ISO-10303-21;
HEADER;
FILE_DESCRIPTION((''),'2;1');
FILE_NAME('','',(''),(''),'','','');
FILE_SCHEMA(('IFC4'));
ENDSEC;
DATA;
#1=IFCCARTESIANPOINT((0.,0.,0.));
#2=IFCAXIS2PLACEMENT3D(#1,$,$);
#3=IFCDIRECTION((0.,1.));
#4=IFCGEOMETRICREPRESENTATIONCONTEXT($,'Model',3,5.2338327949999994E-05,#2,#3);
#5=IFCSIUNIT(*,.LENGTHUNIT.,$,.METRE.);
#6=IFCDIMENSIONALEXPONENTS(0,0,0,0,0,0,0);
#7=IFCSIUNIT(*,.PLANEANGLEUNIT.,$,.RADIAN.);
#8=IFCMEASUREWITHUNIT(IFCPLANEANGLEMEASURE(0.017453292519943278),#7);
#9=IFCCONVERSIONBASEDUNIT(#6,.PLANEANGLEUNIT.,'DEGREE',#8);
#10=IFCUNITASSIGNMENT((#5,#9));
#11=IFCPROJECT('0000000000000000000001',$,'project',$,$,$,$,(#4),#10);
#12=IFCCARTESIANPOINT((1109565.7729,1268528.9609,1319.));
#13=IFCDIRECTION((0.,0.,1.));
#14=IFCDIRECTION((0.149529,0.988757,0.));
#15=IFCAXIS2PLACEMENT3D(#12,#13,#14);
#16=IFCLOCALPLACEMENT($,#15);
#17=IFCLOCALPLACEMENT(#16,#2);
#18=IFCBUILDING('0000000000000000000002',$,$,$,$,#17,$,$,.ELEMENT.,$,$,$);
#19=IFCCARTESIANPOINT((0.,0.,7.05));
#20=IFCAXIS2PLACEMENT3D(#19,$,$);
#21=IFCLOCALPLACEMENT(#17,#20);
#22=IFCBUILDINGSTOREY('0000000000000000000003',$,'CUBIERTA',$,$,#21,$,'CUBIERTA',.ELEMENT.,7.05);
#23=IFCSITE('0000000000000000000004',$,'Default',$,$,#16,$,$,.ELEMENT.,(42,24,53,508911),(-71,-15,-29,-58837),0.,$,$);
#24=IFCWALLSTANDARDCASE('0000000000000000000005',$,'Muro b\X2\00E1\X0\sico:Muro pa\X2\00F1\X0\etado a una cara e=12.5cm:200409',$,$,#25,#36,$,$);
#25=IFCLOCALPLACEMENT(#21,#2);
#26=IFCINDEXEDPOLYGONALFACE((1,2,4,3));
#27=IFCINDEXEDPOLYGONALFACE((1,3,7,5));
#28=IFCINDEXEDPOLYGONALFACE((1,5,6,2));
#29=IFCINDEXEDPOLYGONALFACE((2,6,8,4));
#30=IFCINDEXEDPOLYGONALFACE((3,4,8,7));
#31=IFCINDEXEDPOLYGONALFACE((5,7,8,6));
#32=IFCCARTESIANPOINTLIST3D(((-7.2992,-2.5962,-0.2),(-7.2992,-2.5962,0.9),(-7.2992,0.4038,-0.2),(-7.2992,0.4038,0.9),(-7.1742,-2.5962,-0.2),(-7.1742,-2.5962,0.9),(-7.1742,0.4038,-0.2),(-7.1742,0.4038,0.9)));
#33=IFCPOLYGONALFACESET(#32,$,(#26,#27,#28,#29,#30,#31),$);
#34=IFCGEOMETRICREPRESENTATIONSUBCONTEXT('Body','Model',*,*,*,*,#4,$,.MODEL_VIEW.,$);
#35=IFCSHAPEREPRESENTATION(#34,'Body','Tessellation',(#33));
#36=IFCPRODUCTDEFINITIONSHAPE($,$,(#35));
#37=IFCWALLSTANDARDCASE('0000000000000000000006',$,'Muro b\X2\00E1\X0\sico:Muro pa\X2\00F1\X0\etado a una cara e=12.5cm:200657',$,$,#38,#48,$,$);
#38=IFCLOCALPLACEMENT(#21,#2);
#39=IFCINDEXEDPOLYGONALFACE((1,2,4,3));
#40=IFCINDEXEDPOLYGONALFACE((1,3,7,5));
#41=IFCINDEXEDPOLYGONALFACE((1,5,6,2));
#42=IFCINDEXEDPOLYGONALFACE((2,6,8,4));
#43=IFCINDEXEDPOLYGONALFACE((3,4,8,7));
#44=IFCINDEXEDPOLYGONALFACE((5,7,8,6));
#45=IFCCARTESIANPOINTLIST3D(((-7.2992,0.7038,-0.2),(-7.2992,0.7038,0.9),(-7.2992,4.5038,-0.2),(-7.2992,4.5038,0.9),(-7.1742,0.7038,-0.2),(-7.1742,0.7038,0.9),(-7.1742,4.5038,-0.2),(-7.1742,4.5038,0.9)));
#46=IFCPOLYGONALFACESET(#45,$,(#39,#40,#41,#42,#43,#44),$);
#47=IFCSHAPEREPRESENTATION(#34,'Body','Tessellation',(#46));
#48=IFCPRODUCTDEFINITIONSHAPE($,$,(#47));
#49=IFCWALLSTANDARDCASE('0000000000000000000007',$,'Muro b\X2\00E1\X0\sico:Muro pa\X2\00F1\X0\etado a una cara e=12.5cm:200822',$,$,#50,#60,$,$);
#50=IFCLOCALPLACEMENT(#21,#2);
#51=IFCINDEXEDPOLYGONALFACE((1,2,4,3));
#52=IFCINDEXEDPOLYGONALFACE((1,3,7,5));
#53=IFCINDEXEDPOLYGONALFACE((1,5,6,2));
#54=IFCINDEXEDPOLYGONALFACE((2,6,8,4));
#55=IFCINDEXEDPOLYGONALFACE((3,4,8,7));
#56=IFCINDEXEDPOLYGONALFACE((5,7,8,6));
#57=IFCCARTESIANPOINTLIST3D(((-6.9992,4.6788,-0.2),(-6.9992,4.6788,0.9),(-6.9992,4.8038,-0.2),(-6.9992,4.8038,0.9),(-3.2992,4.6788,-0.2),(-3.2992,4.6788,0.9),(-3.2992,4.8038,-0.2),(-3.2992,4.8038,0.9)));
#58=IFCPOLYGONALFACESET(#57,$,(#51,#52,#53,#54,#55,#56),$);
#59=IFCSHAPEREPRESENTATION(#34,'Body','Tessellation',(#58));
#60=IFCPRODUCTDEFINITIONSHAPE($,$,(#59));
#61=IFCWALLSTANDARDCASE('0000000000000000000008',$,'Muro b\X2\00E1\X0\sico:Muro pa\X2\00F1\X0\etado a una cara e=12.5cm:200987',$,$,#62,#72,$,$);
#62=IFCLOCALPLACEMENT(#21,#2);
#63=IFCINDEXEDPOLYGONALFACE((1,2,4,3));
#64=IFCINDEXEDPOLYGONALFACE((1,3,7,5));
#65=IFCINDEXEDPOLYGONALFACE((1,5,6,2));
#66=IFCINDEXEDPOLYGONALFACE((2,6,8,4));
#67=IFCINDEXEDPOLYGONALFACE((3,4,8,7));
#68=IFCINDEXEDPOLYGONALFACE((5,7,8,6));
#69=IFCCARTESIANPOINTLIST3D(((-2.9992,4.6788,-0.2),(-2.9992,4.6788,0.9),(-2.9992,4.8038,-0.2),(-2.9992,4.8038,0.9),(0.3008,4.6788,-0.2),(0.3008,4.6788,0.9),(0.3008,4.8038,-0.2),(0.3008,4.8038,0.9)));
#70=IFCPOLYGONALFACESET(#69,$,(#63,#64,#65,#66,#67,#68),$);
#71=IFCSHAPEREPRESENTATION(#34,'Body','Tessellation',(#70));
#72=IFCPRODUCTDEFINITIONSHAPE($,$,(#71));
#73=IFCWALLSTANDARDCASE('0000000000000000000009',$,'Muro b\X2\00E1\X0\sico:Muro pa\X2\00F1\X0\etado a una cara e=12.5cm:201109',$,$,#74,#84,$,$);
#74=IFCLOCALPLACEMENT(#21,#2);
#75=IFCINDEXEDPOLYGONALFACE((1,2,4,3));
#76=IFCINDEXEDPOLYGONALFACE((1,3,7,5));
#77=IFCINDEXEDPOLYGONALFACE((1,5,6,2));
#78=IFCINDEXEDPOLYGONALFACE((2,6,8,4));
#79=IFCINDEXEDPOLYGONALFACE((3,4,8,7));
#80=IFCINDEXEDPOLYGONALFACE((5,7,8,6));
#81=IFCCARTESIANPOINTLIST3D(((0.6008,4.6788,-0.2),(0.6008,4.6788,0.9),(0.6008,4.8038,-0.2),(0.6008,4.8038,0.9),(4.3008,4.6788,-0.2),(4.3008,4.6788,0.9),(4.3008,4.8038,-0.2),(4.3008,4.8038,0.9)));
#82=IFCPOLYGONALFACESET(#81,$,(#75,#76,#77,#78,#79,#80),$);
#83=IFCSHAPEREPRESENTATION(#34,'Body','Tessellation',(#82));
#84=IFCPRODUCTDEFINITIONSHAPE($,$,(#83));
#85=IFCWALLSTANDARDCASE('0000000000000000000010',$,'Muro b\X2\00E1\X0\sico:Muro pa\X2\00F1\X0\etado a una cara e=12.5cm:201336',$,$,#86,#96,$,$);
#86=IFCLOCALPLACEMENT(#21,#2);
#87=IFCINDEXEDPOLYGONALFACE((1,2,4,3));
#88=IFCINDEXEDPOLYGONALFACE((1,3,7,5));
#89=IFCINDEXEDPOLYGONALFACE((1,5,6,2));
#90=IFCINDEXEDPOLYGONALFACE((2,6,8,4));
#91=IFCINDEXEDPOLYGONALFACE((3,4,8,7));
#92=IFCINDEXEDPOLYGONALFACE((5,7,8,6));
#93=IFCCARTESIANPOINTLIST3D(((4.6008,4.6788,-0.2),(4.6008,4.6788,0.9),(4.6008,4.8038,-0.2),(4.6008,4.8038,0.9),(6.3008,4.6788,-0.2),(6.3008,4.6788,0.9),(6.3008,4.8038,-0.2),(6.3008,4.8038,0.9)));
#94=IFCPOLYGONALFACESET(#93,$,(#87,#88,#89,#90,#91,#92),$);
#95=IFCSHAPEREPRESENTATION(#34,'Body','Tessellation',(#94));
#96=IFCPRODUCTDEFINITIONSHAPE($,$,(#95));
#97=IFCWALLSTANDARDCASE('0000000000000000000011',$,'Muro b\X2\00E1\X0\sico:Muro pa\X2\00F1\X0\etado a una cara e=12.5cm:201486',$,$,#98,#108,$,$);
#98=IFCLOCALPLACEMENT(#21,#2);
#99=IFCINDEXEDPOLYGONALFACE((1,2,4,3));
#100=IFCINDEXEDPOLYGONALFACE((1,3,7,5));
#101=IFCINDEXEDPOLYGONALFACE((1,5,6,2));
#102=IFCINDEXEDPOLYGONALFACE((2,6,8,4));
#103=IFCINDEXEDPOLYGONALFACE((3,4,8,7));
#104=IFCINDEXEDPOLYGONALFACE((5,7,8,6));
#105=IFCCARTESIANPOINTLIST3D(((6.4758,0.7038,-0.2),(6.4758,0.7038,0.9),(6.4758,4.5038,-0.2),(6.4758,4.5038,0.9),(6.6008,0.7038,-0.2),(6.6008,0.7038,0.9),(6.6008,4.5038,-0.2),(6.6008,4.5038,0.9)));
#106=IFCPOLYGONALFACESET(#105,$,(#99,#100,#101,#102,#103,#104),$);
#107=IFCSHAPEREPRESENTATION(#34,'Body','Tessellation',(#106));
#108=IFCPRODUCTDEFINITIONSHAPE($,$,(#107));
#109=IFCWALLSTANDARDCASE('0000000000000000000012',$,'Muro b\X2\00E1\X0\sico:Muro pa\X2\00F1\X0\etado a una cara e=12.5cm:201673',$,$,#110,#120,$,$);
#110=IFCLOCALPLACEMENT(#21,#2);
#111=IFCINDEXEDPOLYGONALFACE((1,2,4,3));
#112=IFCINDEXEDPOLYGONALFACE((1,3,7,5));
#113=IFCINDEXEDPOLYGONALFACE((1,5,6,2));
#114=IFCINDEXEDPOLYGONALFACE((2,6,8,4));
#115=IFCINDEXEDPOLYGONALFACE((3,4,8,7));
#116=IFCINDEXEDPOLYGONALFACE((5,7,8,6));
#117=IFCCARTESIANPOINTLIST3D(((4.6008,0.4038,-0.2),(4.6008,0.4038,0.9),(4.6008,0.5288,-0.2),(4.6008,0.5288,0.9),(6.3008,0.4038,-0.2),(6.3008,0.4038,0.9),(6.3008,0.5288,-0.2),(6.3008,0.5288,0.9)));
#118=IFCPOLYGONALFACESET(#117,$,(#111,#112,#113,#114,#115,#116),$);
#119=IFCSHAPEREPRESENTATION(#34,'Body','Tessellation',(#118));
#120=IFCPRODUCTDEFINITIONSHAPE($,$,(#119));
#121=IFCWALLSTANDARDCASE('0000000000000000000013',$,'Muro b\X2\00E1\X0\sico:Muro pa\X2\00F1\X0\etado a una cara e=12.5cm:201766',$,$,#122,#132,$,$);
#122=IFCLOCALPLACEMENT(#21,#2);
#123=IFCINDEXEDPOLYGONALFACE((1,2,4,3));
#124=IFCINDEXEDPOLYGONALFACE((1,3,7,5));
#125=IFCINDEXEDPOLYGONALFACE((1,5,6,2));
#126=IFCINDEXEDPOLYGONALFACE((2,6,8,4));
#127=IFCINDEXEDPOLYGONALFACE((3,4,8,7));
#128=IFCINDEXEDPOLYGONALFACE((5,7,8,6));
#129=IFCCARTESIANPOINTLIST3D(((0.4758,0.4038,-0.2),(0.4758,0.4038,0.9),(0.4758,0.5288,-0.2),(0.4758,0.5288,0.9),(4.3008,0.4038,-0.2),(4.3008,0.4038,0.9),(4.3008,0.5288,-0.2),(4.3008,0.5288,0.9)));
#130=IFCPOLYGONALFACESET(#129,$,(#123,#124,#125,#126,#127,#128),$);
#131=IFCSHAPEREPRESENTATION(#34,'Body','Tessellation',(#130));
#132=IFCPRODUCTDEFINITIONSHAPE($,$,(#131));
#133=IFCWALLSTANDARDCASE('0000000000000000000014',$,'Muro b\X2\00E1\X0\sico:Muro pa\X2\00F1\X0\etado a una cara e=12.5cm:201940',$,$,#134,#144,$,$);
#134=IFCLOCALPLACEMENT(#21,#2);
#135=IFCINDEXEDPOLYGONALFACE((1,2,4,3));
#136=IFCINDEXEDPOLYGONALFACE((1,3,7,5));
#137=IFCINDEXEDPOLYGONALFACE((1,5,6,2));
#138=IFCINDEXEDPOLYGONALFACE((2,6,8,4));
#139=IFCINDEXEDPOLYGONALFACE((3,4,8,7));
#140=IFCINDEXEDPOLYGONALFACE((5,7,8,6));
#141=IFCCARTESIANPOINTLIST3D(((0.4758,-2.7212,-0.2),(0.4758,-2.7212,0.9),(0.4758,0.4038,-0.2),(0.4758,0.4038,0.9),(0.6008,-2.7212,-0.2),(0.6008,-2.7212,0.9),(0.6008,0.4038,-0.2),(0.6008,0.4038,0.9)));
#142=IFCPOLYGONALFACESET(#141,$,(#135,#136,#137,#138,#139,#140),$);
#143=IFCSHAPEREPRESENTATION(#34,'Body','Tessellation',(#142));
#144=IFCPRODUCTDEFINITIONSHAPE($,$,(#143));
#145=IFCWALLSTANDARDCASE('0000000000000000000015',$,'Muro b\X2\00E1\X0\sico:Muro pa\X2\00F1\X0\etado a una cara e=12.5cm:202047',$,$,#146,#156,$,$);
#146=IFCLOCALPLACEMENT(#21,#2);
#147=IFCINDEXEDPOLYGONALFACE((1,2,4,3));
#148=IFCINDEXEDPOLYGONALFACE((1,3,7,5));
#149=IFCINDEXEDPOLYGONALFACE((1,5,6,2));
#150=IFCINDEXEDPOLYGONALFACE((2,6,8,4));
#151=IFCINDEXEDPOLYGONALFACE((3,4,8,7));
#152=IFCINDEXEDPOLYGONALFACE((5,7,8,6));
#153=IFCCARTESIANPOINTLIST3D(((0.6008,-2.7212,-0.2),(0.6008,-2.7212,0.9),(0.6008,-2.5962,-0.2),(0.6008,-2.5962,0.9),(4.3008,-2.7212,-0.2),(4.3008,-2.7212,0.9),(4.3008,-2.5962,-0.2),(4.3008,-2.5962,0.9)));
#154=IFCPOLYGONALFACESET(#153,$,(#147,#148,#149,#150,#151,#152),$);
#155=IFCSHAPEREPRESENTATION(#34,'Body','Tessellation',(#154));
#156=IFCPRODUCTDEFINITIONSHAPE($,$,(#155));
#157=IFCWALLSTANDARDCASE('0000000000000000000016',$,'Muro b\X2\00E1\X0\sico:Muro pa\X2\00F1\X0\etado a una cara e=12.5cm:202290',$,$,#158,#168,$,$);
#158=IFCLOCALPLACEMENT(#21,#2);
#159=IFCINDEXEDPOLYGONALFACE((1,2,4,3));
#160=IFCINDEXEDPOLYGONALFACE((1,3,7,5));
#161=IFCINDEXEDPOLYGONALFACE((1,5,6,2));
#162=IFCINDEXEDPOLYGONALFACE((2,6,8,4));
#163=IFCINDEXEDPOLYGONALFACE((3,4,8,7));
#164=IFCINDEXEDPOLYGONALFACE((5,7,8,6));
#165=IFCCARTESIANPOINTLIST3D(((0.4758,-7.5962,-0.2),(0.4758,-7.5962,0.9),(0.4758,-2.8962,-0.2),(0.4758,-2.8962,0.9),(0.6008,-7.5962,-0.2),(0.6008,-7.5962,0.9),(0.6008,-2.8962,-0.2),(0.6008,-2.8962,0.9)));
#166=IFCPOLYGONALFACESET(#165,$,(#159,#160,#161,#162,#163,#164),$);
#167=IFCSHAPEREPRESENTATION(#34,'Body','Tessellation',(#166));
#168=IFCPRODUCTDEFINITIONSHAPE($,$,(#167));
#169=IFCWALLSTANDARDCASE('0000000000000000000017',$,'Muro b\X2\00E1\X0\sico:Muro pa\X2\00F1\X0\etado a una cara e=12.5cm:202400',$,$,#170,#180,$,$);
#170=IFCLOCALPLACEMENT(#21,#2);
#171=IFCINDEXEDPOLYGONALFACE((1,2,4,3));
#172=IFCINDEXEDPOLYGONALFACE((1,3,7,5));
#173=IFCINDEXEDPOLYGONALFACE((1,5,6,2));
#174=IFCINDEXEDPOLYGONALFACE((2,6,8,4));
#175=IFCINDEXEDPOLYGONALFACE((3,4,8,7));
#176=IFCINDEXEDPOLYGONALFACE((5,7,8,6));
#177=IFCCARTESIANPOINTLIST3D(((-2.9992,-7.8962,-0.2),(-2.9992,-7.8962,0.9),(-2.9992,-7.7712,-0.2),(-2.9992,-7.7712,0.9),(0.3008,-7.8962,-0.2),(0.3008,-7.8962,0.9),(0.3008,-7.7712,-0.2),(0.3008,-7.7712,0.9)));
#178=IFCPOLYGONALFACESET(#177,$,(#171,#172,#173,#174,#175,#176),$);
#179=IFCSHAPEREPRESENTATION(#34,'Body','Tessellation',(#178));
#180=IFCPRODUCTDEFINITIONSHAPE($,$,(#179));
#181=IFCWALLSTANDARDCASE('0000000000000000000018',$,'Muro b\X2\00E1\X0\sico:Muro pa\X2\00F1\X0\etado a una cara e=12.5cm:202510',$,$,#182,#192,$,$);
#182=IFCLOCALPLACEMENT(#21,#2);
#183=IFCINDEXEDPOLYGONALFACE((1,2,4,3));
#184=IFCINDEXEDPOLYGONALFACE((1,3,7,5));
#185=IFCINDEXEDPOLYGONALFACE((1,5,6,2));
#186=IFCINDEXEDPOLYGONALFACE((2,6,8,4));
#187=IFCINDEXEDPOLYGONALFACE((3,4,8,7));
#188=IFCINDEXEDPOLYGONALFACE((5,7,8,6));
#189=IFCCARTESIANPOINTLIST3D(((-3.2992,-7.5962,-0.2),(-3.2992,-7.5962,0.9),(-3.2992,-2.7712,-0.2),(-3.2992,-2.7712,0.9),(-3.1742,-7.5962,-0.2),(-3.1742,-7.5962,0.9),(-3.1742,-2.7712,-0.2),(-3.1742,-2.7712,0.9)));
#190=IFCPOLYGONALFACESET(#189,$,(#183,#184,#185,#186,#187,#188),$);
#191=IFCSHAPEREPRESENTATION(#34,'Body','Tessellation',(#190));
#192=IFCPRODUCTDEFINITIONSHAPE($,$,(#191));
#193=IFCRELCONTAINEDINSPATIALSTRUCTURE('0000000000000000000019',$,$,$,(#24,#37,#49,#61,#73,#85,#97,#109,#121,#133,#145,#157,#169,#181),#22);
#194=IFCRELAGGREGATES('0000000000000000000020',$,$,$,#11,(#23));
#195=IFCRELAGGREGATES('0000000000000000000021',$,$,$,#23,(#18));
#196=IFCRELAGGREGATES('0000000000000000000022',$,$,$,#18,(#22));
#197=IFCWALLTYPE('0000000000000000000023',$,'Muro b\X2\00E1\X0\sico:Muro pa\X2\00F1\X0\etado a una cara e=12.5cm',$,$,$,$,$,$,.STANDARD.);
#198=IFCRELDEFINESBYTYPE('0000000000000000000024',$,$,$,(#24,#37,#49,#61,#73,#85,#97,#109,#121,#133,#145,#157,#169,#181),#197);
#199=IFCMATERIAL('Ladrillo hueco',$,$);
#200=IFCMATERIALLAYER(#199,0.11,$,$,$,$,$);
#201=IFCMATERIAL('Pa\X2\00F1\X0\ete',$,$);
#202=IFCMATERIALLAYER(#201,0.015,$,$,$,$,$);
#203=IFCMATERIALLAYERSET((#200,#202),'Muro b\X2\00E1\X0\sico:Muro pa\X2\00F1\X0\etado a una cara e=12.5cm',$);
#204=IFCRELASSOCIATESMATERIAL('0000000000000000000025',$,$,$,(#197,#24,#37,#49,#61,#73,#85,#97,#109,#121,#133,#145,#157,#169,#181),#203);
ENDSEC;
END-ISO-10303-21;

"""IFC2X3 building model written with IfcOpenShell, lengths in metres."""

from ifc_helpers import new_model, entity, si_unit, converted_unit, direction, frame, frame_2d, origin, place, context, subcontext, project, spatial, rectangle, extrude, material, layer, layer_set, layer_usage, type_object, element, save


model = new_model("IFC2X3")

# Units and contexts
model_context = context("Model", 3, precision=5.2338327949999994e-05, world=origin(), true_north=direction((0.0, 1.0)))
body_context = subcontext(model_context, "Body", "Model", "MODEL_VIEW")
ifc_project = project(units=[si_unit("LENGTHUNIT", "METRE"), converted_unit("PLANEANGLEUNIT", "DEGREE", entity("IfcPlaneAngleMeasure", 0.017453292519943278), si_unit("PLANEANGLEUNIT", "RADIAN"), dimensions=[0, 0, 0, 0, 0, 0, 0])], contexts=[model_context])

# Site, building, storey
site_placement = place(None, frame((1109565.7729, 1268528.9609, 1319.0), z_axis=(0.0, 0.0, 1.0), x_axis=(0.149529, 0.988757, 0.0)))
site = spatial("IfcSite", under=ifc_project, at=site_placement, Name="Default", CompositionType="ELEMENT", RefLatitude=(42, 24, 53, 508911), RefLongitude=(-71, -15, -29, -58837), RefElevation=0.0)
building_placement = place(site_placement, origin())
building = spatial("IfcBuilding", under=site, at=building_placement, CompositionType="ELEMENT")
storey_placement = place(building_placement, frame((0.0, 0.0, 7.05)))
storey = spatial("IfcBuildingStorey", under=building, at=storey_placement, Name="CUBIERTA", LongName="CUBIERTA", CompositionType="ELEMENT", Elevation=7.05)

# Walls
ifc_material_1 = material(Name="Ladrillo hueco")
ifc_layer_1 = layer(ifc_material_1, 0.11)
ifc_material_2 = material(Name="Pañete")
ifc_layer_2 = layer(ifc_material_2, 0.015)
ifc_layer_set_1 = layer_set([ifc_layer_1, ifc_layer_2], Name="Muro básico:Muro pañetado a una cara e=12.5cm")
ifc_layer_usage_1 = layer_usage(ifc_layer_set_1, "AXIS2", "NEGATIVE", 0.0625)
wall_type_1 = type_object("IfcWallType", Name="Muro básico:Muro pañetado a una cara e=12.5cm", PredefinedType="STANDARD", material=ifc_layer_set_1)
wall_1_placement = place(storey_placement, frame((-7.2367, -2.5962, -0.2), z_axis=(0.0, 0.0, 1.0), x_axis=(0.0, 1.0, 0.0)))
element("IfcWallStandardCase", 1, at=wall_1_placement, inside=storey, type_object=wall_type_1, material=ifc_layer_usage_1, Name="Muro básico:Muro pañetado a una cara e=12.5cm:200409", context=body_context, shape_type="SweptSolid", body=[
    extrude(rectangle(XDim=3.0, YDim=0.125, at=frame_2d((1.5, 0.0), x_axis=(-1.0, 0.0))), origin(), (0.0, 0.0, 1.0), 1.1),
])
ifc_layer_usage_2 = layer_usage(ifc_layer_set_1, "AXIS2", "NEGATIVE", 0.0625)
wall_2_placement = place(storey_placement, frame((-7.2367, 0.7038, -0.2), z_axis=(0.0, 0.0, 1.0), x_axis=(0.0, 1.0, 0.0)))
element("IfcWallStandardCase", 2, at=wall_2_placement, inside=storey, type_object=wall_type_1, material=ifc_layer_usage_2, Name="Muro básico:Muro pañetado a una cara e=12.5cm:200657", context=body_context, shape_type="SweptSolid", body=[
    extrude(rectangle(XDim=3.8, YDim=0.125, at=frame_2d((1.9, 0.0), x_axis=(-1.0, 0.0))), origin(), (0.0, 0.0, 1.0), 1.1),
])
ifc_layer_usage_3 = layer_usage(ifc_layer_set_1, "AXIS2", "NEGATIVE", 0.0625)
wall_3_placement = place(storey_placement, frame((-6.9992, 4.7413, -0.2)))
element("IfcWallStandardCase", 3, at=wall_3_placement, inside=storey, type_object=wall_type_1, material=ifc_layer_usage_3, Name="Muro básico:Muro pañetado a una cara e=12.5cm:200822", context=body_context, shape_type="SweptSolid", body=[
    extrude(rectangle(XDim=3.7, YDim=0.125, at=frame_2d((1.85, 0.0), x_axis=(-1.0, 0.0))), origin(), (0.0, 0.0, 1.0), 1.1),
])
ifc_layer_usage_4 = layer_usage(ifc_layer_set_1, "AXIS2", "NEGATIVE", 0.0625)
wall_4_placement = place(storey_placement, frame((-2.9992, 4.7413, -0.2)))
element("IfcWallStandardCase", 4, at=wall_4_placement, inside=storey, type_object=wall_type_1, material=ifc_layer_usage_4, Name="Muro básico:Muro pañetado a una cara e=12.5cm:200987", context=body_context, shape_type="SweptSolid", body=[
    extrude(rectangle(XDim=3.3, YDim=0.125, at=frame_2d((1.65, 0.0), x_axis=(-1.0, 0.0))), origin(), (0.0, 0.0, 1.0), 1.1),
])
ifc_layer_usage_5 = layer_usage(ifc_layer_set_1, "AXIS2", "NEGATIVE", 0.0625)
wall_5_placement = place(storey_placement, frame((0.6008, 4.7413, -0.2)))
element("IfcWallStandardCase", 5, at=wall_5_placement, inside=storey, type_object=wall_type_1, material=ifc_layer_usage_5, Name="Muro básico:Muro pañetado a una cara e=12.5cm:201109", context=body_context, shape_type="SweptSolid", body=[
    extrude(rectangle(XDim=3.7, YDim=0.125, at=frame_2d((1.85, 0.0), x_axis=(-1.0, 0.0))), origin(), (0.0, 0.0, 1.0), 1.1),
])
ifc_layer_usage_6 = layer_usage(ifc_layer_set_1, "AXIS2", "NEGATIVE", 0.0625)
wall_6_placement = place(storey_placement, frame((4.6008, 4.7413, -0.2)))
element("IfcWallStandardCase", 6, at=wall_6_placement, inside=storey, type_object=wall_type_1, material=ifc_layer_usage_6, Name="Muro básico:Muro pañetado a una cara e=12.5cm:201336", context=body_context, shape_type="SweptSolid", body=[
    extrude(rectangle(XDim=1.7, YDim=0.125, at=frame_2d((0.85, 0.0), x_axis=(-1.0, 0.0))), origin(), (0.0, 0.0, 1.0), 1.1),
])
ifc_layer_usage_7 = layer_usage(ifc_layer_set_1, "AXIS2", "NEGATIVE", 0.0625)
wall_7_placement = place(storey_placement, frame((6.5383, 4.5038, -0.2), z_axis=(0.0, 0.0, 1.0), x_axis=(0.0, -1.0, 0.0)))
element("IfcWallStandardCase", 7, at=wall_7_placement, inside=storey, type_object=wall_type_1, material=ifc_layer_usage_7, Name="Muro básico:Muro pañetado a una cara e=12.5cm:201486", context=body_context, shape_type="SweptSolid", body=[
    extrude(rectangle(XDim=3.8, YDim=0.125, at=frame_2d((1.9, 0.0), x_axis=(-1.0, 0.0))), origin(), (0.0, 0.0, 1.0), 1.1),
])
ifc_layer_usage_8 = layer_usage(ifc_layer_set_1, "AXIS2", "NEGATIVE", 0.0625)
wall_8_placement = place(storey_placement, frame((6.3008, 0.4663, -0.2), z_axis=(0.0, 0.0, 1.0), x_axis=(-1.0, 0.0, 0.0)))
element("IfcWallStandardCase", 8, at=wall_8_placement, inside=storey, type_object=wall_type_1, material=ifc_layer_usage_8, Name="Muro básico:Muro pañetado a una cara e=12.5cm:201673", context=body_context, shape_type="SweptSolid", body=[
    extrude(rectangle(XDim=1.7, YDim=0.125, at=frame_2d((0.85, 0.0), x_axis=(-1.0, 0.0))), origin(), (0.0, 0.0, 1.0), 1.1),
])
ifc_layer_usage_9 = layer_usage(ifc_layer_set_1, "AXIS2", "NEGATIVE", 0.0625)
wall_9_placement = place(storey_placement, frame((4.3008, 0.4663, -0.2), z_axis=(0.0, 0.0, 1.0), x_axis=(-1.0, 0.0, 0.0)))
element("IfcWallStandardCase", 9, at=wall_9_placement, inside=storey, type_object=wall_type_1, material=ifc_layer_usage_9, Name="Muro básico:Muro pañetado a una cara e=12.5cm:201766", context=body_context, shape_type="SweptSolid", body=[
    extrude(rectangle(XDim=3.825, YDim=0.125, at=frame_2d((1.9125, 0.0), x_axis=(-1.0, 0.0))), origin(), (0.0, 0.0, 1.0), 1.1),
])
ifc_layer_usage_10 = layer_usage(ifc_layer_set_1, "AXIS2", "NEGATIVE", 0.0625)
wall_10_placement = place(storey_placement, frame((0.5383, 0.4038, -0.2), z_axis=(0.0, 0.0, 1.0), x_axis=(0.0, -1.0, 0.0)))
element("IfcWallStandardCase", 10, at=wall_10_placement, inside=storey, type_object=wall_type_1, material=ifc_layer_usage_10, Name="Muro básico:Muro pañetado a una cara e=12.5cm:201940", context=body_context, shape_type="SweptSolid", body=[
    extrude(rectangle(XDim=3.125, YDim=0.125, at=frame_2d((1.5625, 0.0), x_axis=(-1.0, 0.0))), origin(), (0.0, 0.0, 1.0), 1.1),
])
ifc_layer_usage_11 = layer_usage(ifc_layer_set_1, "AXIS2", "NEGATIVE", 0.0625)
wall_11_placement = place(storey_placement, frame((0.6008, -2.6587, -0.2)))
element("IfcWallStandardCase", 11, at=wall_11_placement, inside=storey, type_object=wall_type_1, material=ifc_layer_usage_11, Name="Muro básico:Muro pañetado a una cara e=12.5cm:202047", context=body_context, shape_type="SweptSolid", body=[
    extrude(rectangle(XDim=3.7, YDim=0.125, at=frame_2d((1.85, 0.0), x_axis=(-1.0, 0.0))), origin(), (0.0, 0.0, 1.0), 1.1),
])
ifc_layer_usage_12 = layer_usage(ifc_layer_set_1, "AXIS2", "NEGATIVE", 0.0625)
wall_12_placement = place(storey_placement, frame((0.5383, -2.8962, -0.2), z_axis=(0.0, 0.0, 1.0), x_axis=(0.0, -1.0, 0.0)))
element("IfcWallStandardCase", 12, at=wall_12_placement, inside=storey, type_object=wall_type_1, material=ifc_layer_usage_12, Name="Muro básico:Muro pañetado a una cara e=12.5cm:202290", context=body_context, shape_type="SweptSolid", body=[
    extrude(rectangle(XDim=4.7, YDim=0.125, at=frame_2d((2.35, 0.0), x_axis=(-1.0, 0.0))), origin(), (0.0, 0.0, 1.0), 1.1),
])
ifc_layer_usage_13 = layer_usage(ifc_layer_set_1, "AXIS2", "NEGATIVE", 0.0625)
wall_13_placement = place(storey_placement, frame((0.3008, -7.8337, -0.2), z_axis=(0.0, 0.0, 1.0), x_axis=(-1.0, 0.0, 0.0)))
element("IfcWallStandardCase", 13, at=wall_13_placement, inside=storey, type_object=wall_type_1, material=ifc_layer_usage_13, Name="Muro básico:Muro pañetado a una cara e=12.5cm:202400", context=body_context, shape_type="SweptSolid", body=[
    extrude(rectangle(XDim=3.3, YDim=0.125, at=frame_2d((1.65, 0.0), x_axis=(-1.0, 0.0))), origin(), (0.0, 0.0, 1.0), 1.1),
])
ifc_layer_usage_14 = layer_usage(ifc_layer_set_1, "AXIS2", "NEGATIVE", 0.0625)
wall_14_placement = place(storey_placement, frame((-3.2367, -7.5962, -0.2), z_axis=(0.0, 0.0, 1.0), x_axis=(0.0, 1.0, 0.0)))
element("IfcWallStandardCase", 14, at=wall_14_placement, inside=storey, type_object=wall_type_1, material=ifc_layer_usage_14, Name="Muro básico:Muro pañetado a una cara e=12.5cm:202510", context=body_context, shape_type="SweptSolid", body=[
    extrude(rectangle(XDim=4.825, YDim=0.125, at=frame_2d((2.4125, 0.0), x_axis=(-1.0, 0.0))), origin(), (0.0, 0.0, 1.0), 1.1),
])

save(model, "model.ifc")
